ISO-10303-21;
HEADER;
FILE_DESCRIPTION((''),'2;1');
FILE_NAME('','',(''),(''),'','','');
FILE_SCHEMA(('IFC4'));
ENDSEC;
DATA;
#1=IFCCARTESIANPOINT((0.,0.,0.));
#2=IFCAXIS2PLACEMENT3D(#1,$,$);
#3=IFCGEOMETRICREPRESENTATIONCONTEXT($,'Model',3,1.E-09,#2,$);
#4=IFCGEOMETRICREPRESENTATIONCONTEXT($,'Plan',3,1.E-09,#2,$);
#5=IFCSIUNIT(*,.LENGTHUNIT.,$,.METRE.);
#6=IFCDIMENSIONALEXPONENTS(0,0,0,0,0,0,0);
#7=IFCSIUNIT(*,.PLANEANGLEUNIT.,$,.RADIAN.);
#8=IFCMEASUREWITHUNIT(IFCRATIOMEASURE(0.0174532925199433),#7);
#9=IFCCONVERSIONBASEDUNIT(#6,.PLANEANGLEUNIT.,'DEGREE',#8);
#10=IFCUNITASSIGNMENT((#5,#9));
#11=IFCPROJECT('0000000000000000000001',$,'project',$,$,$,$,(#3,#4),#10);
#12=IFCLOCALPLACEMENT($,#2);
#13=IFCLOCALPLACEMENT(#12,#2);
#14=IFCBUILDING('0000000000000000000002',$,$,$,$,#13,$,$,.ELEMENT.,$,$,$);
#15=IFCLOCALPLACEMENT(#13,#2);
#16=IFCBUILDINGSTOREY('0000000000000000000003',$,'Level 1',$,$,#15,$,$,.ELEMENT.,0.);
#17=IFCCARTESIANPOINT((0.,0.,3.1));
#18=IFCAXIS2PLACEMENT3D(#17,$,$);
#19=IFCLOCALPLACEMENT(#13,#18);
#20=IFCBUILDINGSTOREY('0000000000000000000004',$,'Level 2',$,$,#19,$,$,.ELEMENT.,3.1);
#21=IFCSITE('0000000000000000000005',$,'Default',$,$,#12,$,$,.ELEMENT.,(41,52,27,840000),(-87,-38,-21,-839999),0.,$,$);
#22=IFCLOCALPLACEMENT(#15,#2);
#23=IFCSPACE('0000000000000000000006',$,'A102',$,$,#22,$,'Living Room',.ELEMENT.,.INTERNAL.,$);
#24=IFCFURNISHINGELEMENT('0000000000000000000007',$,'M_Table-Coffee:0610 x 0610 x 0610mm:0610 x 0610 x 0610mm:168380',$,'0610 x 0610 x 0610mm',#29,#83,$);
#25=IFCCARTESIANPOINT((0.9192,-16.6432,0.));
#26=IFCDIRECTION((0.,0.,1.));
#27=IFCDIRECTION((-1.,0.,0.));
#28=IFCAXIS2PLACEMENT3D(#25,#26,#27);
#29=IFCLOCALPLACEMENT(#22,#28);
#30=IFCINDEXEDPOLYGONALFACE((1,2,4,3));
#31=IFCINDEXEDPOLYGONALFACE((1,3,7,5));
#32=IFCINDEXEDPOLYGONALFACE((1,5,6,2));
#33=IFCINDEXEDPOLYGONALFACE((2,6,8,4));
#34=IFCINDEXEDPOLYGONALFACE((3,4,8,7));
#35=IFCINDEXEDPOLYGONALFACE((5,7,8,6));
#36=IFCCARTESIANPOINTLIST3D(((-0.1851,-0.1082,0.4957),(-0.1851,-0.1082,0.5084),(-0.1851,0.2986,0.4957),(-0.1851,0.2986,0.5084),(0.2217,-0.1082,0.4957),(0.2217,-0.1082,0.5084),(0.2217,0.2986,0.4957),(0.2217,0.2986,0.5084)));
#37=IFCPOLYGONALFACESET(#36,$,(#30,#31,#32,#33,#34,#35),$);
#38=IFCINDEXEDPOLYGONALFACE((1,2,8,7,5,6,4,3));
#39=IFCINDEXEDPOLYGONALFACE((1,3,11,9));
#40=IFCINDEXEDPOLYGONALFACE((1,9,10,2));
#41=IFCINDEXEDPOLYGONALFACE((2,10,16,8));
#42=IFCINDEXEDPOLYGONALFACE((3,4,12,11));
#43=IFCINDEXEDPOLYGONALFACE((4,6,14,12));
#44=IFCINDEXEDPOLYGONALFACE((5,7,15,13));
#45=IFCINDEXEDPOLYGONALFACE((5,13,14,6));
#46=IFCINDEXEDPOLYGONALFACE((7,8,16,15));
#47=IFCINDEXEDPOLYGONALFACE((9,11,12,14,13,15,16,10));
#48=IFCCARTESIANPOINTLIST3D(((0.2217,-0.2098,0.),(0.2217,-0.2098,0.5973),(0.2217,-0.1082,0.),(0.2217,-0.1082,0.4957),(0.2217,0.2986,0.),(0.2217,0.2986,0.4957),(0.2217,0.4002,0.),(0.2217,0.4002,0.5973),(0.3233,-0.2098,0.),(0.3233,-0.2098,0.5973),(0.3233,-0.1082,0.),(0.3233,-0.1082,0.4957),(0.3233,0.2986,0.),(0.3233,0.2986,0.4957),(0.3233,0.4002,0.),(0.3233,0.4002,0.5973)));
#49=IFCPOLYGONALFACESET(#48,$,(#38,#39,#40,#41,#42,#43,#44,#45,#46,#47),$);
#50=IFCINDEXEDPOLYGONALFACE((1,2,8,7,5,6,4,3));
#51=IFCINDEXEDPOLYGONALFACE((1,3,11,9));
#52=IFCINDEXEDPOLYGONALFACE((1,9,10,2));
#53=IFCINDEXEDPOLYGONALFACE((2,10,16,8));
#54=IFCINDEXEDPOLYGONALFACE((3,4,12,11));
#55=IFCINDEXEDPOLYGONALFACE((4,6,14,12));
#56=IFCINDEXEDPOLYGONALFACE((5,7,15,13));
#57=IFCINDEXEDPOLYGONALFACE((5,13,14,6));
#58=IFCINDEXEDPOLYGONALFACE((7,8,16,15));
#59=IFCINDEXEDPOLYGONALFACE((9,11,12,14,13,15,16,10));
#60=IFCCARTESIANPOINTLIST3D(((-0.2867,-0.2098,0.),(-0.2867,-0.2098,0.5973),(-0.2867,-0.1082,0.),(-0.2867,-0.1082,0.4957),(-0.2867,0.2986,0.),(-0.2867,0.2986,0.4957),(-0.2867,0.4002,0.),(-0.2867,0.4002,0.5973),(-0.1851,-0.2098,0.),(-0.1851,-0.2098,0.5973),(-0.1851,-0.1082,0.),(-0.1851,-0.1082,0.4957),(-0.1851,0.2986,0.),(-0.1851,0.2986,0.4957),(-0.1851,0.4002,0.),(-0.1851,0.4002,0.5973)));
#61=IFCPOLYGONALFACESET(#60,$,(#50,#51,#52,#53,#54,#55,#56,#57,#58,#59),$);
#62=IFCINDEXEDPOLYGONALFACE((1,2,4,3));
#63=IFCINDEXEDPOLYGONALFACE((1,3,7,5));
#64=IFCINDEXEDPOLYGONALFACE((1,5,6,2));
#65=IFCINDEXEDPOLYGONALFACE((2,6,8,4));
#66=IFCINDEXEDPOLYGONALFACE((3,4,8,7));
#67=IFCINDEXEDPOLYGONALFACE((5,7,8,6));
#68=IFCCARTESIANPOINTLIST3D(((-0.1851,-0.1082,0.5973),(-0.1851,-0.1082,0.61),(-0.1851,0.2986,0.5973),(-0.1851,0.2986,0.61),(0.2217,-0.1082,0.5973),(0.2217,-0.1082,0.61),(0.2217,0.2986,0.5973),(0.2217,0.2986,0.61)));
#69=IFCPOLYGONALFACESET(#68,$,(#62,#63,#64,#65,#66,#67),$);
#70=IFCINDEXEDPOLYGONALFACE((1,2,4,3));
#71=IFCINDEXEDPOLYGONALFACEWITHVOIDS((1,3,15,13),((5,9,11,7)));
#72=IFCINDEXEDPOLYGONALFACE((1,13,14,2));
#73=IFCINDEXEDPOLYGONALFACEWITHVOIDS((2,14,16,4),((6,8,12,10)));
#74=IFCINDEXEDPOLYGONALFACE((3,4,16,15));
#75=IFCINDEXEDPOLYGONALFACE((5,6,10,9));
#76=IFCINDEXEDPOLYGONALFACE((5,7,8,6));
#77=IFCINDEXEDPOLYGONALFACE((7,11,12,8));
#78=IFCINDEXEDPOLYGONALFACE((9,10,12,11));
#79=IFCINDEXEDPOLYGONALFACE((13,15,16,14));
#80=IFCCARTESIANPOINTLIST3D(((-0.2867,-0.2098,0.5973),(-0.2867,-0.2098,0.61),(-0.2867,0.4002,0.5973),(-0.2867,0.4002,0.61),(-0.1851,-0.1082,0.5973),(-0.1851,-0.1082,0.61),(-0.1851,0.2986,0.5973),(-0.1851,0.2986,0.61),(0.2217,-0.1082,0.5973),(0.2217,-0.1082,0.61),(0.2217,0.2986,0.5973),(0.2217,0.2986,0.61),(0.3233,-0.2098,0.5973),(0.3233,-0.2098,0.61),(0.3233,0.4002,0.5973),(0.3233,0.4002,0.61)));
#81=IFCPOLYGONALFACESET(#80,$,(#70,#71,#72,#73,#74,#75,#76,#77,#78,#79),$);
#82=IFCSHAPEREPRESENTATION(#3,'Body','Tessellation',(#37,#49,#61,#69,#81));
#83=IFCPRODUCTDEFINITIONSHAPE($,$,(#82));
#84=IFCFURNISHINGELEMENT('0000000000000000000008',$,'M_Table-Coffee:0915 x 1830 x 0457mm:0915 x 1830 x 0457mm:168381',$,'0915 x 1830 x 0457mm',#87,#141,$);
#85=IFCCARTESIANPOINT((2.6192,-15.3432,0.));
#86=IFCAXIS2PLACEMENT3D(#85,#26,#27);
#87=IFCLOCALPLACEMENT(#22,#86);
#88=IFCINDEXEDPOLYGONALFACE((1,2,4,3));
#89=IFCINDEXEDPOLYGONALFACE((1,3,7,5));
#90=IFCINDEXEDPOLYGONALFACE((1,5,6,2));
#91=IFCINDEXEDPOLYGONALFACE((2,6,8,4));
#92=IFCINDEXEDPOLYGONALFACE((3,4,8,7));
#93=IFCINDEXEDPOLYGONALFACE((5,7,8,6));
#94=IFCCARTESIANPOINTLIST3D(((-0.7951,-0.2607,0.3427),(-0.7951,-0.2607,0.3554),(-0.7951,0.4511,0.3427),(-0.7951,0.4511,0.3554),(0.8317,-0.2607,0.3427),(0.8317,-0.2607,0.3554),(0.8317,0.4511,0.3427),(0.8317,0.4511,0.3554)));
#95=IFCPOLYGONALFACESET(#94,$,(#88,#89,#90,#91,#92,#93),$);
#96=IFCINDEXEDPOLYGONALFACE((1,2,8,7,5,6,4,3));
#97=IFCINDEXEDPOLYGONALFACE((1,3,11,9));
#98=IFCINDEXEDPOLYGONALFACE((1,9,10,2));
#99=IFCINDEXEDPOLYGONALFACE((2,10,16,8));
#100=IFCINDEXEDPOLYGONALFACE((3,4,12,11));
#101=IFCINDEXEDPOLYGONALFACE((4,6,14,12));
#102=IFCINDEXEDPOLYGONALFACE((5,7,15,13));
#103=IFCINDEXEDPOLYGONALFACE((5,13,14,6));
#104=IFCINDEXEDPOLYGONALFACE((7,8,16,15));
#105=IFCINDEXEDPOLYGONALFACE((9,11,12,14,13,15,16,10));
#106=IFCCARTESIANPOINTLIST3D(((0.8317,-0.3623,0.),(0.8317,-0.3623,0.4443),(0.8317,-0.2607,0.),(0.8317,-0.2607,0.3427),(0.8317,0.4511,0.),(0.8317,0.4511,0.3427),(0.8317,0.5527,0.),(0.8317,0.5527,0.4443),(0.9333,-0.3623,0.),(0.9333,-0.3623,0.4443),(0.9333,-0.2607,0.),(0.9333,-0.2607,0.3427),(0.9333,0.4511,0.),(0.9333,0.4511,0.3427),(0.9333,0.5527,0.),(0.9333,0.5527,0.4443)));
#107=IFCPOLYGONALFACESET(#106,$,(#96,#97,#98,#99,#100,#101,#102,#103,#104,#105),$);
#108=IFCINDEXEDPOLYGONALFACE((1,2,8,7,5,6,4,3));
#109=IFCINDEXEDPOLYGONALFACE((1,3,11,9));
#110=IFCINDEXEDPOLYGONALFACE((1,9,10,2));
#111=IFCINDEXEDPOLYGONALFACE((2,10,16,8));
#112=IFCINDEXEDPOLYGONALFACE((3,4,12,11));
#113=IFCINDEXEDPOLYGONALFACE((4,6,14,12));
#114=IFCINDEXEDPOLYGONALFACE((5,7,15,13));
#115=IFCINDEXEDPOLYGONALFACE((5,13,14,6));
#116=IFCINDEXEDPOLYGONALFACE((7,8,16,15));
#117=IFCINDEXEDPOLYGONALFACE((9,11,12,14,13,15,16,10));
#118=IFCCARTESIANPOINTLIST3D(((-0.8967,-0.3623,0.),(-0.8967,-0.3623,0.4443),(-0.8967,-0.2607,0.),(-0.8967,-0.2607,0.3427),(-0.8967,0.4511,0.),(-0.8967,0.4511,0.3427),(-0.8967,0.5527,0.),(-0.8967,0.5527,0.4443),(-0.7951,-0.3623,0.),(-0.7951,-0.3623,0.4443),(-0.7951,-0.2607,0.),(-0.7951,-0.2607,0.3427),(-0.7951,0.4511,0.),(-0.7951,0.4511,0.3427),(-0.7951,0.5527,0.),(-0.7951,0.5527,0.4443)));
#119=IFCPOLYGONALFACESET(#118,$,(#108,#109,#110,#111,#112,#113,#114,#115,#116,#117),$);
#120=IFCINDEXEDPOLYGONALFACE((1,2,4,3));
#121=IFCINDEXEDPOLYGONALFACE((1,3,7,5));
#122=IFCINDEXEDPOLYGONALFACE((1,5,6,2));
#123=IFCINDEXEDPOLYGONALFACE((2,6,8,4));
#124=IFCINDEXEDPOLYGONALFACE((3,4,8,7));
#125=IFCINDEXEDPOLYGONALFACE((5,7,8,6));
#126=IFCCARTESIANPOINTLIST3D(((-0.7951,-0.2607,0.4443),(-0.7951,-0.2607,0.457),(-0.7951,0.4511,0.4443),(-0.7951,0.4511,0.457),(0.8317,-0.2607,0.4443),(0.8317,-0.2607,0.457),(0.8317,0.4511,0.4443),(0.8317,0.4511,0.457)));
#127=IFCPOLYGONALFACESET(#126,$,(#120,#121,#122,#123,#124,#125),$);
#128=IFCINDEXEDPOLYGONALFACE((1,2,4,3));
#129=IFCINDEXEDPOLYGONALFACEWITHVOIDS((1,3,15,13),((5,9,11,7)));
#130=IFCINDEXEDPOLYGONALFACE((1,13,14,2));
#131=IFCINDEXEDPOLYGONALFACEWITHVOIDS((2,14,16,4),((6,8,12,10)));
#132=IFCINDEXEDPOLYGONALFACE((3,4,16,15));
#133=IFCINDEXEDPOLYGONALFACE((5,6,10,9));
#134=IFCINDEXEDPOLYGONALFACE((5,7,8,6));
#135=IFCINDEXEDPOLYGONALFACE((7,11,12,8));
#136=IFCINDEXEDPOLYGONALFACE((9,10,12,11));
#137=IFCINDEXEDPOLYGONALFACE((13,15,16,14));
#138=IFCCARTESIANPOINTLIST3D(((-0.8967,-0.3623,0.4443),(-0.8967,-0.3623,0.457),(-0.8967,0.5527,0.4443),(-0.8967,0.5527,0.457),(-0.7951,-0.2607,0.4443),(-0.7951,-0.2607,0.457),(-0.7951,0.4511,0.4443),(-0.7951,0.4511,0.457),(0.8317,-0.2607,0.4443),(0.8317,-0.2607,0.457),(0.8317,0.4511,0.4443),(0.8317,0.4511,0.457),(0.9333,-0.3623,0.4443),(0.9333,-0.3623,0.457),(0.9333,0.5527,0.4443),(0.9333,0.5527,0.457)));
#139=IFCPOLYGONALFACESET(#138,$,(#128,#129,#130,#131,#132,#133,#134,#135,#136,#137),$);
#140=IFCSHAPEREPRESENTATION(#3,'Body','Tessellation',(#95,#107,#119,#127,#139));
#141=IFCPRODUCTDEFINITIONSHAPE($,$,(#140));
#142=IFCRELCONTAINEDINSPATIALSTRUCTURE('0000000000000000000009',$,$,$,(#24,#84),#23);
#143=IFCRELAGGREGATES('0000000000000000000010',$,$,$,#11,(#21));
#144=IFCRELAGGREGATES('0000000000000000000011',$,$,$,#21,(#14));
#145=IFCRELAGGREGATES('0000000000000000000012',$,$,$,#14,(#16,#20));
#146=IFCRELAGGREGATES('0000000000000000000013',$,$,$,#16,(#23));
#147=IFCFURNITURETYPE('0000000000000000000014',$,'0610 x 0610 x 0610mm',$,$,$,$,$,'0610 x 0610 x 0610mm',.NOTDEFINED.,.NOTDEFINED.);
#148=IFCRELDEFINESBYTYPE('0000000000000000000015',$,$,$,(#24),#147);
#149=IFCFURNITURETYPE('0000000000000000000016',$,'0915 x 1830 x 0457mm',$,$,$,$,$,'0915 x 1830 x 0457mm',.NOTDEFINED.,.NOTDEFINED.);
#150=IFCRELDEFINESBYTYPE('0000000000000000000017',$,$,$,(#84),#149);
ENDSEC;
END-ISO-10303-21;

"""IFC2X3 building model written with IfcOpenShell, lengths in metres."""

from ifc_helpers import new_model, entity, si_unit, converted_unit, frame, origin, origin_2d_with_axis, place, context, project, spatial, polyline, rectangle, outline, extrude, source, transform, mapped, type_object, type_shapes, element, save


model = new_model("IFC2X3")

# Units and contexts
model_context = context("Model", 3, precision=1e-09, world=origin())
plan_context = context("Plan", 3, precision=1e-09, world=origin())
ifc_project = project(units=[si_unit("LENGTHUNIT", "METRE"), converted_unit("PLANEANGLEUNIT", "DEGREE", entity("IfcRatioMeasure", 0.0174532925199433), si_unit("PLANEANGLEUNIT", "RADIAN"), dimensions=[0, 0, 0, 0, 0, 0, 0])], contexts=[model_context, plan_context])

# Site, building, storey
site_placement = place(None, origin())
site = spatial("IfcSite", under=ifc_project, at=site_placement, Name="Default", CompositionType="ELEMENT", RefLatitude=(41, 52, 27, 840000), RefLongitude=(-87, -38, -21, -839999), RefElevation=0.0)
building_placement = place(site_placement, origin())
building = spatial("IfcBuilding", under=site, at=building_placement, CompositionType="ELEMENT")
storey_1_placement = place(building_placement, origin())
storey_1 = spatial("IfcBuildingStorey", under=building, at=storey_1_placement, Name="Level 1", CompositionType="ELEMENT", Elevation=0.0)

# Shared definitions
storey_2_placement = place(building_placement, frame((0.0, 0.0, 3.1)))
storey_2 = spatial("IfcBuildingStorey", under=building, at=storey_2_placement, Name="Level 2", CompositionType="ELEMENT", Elevation=3.1)

# Shared definitions
space_1_placement = place(storey_1_placement, origin())
space_1 = spatial("IfcSpace", under=storey_1, at=space_1_placement, Name="A102", LongName="Living Room", CompositionType="ELEMENT", InteriorOrExteriorSpace="INTERNAL")

# Furnishing element
furniture_type_1 = type_object("IfcFurnitureType", Name="0610 x 0610 x 0610mm", ElementType="0610 x 0610 x 0610mm", AssemblyPlace="NOTDEFINED")
shared_shape_1 = source(origin(), model_context, "Body", "SweptSolid", [
    extrude(rectangle(XDim=0.4068, YDim=0.4068, at=origin_2d_with_axis()), frame((0.0183, 0.0952, 0.4957), z_axis=(0.0, 0.0, 1.0), x_axis=(-1.0, 0.0, 0.0)), (0.0, 0.0, 1.0), 0.0127),
    extrude(outline(polyline([(-0.2732, -0.305), (0.324, -0.305), (0.324, 0.305), (-0.2732, 0.305), (-0.2732, 0.2034), (0.2225, 0.2034), (0.2225, -0.2034), (-0.2732, -0.2034), (-0.2732, -0.305)])), frame((0.2217, 0.0952, 0.2732), z_axis=(1.0, 0.0, 0.0), x_axis=(0.0, 0.0, 1.0)), (0.0, 0.0, 1.0), 0.1016),
    extrude(outline(polyline([(-0.305, -0.3241), (0.305, -0.3241), (0.305, 0.2733), (0.2034, 0.2733), (0.2034, -0.2224), (-0.2034, -0.2224), (-0.2034, 0.2733), (-0.305, 0.2733), (-0.305, -0.3241)])), frame((-0.2867, 0.0952, 0.2733), z_axis=(1.0, 0.0, 0.0), x_axis=(0.0, -1.0, 0.0)), (0.0, 0.0, 1.0), 0.1016),
    extrude(rectangle(XDim=0.4068, YDim=0.4068, at=origin_2d_with_axis()), frame((0.0183, 0.0952, 0.5973), z_axis=(0.0, 0.0, 1.0), x_axis=(-1.0, 0.0, 0.0)), (0.0, 0.0, 1.0), 0.0127),
    extrude(outline(polyline([(-0.305, -0.305), (0.305, -0.305), (0.305, 0.305), (-0.305, 0.305), (-0.305, -0.305)]), holes=[polyline([(-0.2034, -0.2034), (-0.2034, 0.2034), (0.2034, 0.2034), (0.2034, -0.2034), (-0.2034, -0.2034)])]), frame((0.0183, 0.0952, 0.5973), z_axis=(0.0, 0.0, 1.0), x_axis=(-1.0, 0.0, 0.0)), (0.0, 0.0, 1.0), 0.0127),
])
type_shapes(furniture_type_1, [shared_shape_1])
for number, where, z_axis, x_axis, name in (
    (1, (0.9192, -16.6432, 0.0), (0.0, 0.0, 1.0), (-1.0, 0.0, 0.0), "M_Table-Coffee:0610 x 0610 x 0610mm:0610 x 0610 x 0610mm:168380"),
):
    element("IfcFurnishingElement", number, at=place(space_1_placement, frame(where, z_axis=z_axis, x_axis=x_axis)), inside=space_1, type_object=furniture_type_1, Name=name, ObjectType="0610 x 0610 x 0610mm", context=model_context, shape_type="MappedRepresentation", body=[
        mapped(shared_shape_1, transform((0.0, 0.0, 0.0), scale=1.0)),
    ])

# Furnishing element
furniture_type_2 = type_object("IfcFurnitureType", Name="0915 x 1830 x 0457mm", ElementType="0915 x 1830 x 0457mm", AssemblyPlace="NOTDEFINED")
shared_shape_2 = source(origin(), model_context, "Body", "SweptSolid", [
    extrude(rectangle(XDim=1.6268, YDim=0.7118, at=origin_2d_with_axis()), frame((0.0183, 0.0952, 0.3427), z_axis=(0.0, 0.0, 1.0), x_axis=(-1.0, 0.0, 0.0)), (0.0, 0.0, 1.0), 0.0127),
    extrude(outline(polyline([(-0.1967, -0.4575), (0.2475, -0.4575), (0.2475, 0.4575), (-0.1967, 0.4575), (-0.1967, 0.3559), (0.146, 0.3559), (0.146, -0.3559), (-0.1967, -0.3559), (-0.1967, -0.4575)])), frame((0.8317, 0.0952, 0.1967), z_axis=(1.0, 0.0, 0.0), x_axis=(0.0, 0.0, 1.0)), (0.0, 0.0, 1.0), 0.1016),
    extrude(outline(polyline([(-0.4575, -0.2476), (0.4575, -0.2476), (0.4575, 0.1968), (0.3559, 0.1968), (0.3559, -0.1459), (-0.3559, -0.1459), (-0.3559, 0.1968), (-0.4575, 0.1968), (-0.4575, -0.2476)])), frame((-0.8967, 0.0952, 0.1968), z_axis=(1.0, 0.0, 0.0), x_axis=(0.0, -1.0, 0.0)), (0.0, 0.0, 1.0), 0.1016),
    extrude(rectangle(XDim=1.6268, YDim=0.7118, at=origin_2d_with_axis()), frame((0.0183, 0.0952, 0.4443), z_axis=(0.0, 0.0, 1.0), x_axis=(-1.0, 0.0, 0.0)), (0.0, 0.0, 1.0), 0.0127),
    extrude(outline(polyline([(-0.915, -0.4575), (0.915, -0.4575), (0.915, 0.4575), (-0.915, 0.4575), (-0.915, -0.4575)]), holes=[polyline([(-0.8134, -0.3559), (-0.8134, 0.3559), (0.8134, 0.3559), (0.8134, -0.3559), (-0.8134, -0.3559)])]), frame((0.0183, 0.0952, 0.4443), z_axis=(0.0, 0.0, 1.0), x_axis=(-1.0, 0.0, 0.0)), (0.0, 0.0, 1.0), 0.0127),
])
type_shapes(furniture_type_2, [shared_shape_2])
furnishing_1_placement = place(space_1_placement, frame((2.6192, -15.3432, 0.0), z_axis=(0.0, 0.0, 1.0), x_axis=(-1.0, 0.0, 0.0)))
element("IfcFurnishingElement", 2, at=furnishing_1_placement, inside=space_1, type_object=furniture_type_2, Name="M_Table-Coffee:0915 x 1830 x 0457mm:0915 x 1830 x 0457mm:168381", ObjectType="0915 x 1830 x 0457mm", context=model_context, shape_type="MappedRepresentation", body=[
    mapped(shared_shape_2, transform((0.0, 0.0, 0.0), scale=1.0)),
])

save(model, "model.ifc")
